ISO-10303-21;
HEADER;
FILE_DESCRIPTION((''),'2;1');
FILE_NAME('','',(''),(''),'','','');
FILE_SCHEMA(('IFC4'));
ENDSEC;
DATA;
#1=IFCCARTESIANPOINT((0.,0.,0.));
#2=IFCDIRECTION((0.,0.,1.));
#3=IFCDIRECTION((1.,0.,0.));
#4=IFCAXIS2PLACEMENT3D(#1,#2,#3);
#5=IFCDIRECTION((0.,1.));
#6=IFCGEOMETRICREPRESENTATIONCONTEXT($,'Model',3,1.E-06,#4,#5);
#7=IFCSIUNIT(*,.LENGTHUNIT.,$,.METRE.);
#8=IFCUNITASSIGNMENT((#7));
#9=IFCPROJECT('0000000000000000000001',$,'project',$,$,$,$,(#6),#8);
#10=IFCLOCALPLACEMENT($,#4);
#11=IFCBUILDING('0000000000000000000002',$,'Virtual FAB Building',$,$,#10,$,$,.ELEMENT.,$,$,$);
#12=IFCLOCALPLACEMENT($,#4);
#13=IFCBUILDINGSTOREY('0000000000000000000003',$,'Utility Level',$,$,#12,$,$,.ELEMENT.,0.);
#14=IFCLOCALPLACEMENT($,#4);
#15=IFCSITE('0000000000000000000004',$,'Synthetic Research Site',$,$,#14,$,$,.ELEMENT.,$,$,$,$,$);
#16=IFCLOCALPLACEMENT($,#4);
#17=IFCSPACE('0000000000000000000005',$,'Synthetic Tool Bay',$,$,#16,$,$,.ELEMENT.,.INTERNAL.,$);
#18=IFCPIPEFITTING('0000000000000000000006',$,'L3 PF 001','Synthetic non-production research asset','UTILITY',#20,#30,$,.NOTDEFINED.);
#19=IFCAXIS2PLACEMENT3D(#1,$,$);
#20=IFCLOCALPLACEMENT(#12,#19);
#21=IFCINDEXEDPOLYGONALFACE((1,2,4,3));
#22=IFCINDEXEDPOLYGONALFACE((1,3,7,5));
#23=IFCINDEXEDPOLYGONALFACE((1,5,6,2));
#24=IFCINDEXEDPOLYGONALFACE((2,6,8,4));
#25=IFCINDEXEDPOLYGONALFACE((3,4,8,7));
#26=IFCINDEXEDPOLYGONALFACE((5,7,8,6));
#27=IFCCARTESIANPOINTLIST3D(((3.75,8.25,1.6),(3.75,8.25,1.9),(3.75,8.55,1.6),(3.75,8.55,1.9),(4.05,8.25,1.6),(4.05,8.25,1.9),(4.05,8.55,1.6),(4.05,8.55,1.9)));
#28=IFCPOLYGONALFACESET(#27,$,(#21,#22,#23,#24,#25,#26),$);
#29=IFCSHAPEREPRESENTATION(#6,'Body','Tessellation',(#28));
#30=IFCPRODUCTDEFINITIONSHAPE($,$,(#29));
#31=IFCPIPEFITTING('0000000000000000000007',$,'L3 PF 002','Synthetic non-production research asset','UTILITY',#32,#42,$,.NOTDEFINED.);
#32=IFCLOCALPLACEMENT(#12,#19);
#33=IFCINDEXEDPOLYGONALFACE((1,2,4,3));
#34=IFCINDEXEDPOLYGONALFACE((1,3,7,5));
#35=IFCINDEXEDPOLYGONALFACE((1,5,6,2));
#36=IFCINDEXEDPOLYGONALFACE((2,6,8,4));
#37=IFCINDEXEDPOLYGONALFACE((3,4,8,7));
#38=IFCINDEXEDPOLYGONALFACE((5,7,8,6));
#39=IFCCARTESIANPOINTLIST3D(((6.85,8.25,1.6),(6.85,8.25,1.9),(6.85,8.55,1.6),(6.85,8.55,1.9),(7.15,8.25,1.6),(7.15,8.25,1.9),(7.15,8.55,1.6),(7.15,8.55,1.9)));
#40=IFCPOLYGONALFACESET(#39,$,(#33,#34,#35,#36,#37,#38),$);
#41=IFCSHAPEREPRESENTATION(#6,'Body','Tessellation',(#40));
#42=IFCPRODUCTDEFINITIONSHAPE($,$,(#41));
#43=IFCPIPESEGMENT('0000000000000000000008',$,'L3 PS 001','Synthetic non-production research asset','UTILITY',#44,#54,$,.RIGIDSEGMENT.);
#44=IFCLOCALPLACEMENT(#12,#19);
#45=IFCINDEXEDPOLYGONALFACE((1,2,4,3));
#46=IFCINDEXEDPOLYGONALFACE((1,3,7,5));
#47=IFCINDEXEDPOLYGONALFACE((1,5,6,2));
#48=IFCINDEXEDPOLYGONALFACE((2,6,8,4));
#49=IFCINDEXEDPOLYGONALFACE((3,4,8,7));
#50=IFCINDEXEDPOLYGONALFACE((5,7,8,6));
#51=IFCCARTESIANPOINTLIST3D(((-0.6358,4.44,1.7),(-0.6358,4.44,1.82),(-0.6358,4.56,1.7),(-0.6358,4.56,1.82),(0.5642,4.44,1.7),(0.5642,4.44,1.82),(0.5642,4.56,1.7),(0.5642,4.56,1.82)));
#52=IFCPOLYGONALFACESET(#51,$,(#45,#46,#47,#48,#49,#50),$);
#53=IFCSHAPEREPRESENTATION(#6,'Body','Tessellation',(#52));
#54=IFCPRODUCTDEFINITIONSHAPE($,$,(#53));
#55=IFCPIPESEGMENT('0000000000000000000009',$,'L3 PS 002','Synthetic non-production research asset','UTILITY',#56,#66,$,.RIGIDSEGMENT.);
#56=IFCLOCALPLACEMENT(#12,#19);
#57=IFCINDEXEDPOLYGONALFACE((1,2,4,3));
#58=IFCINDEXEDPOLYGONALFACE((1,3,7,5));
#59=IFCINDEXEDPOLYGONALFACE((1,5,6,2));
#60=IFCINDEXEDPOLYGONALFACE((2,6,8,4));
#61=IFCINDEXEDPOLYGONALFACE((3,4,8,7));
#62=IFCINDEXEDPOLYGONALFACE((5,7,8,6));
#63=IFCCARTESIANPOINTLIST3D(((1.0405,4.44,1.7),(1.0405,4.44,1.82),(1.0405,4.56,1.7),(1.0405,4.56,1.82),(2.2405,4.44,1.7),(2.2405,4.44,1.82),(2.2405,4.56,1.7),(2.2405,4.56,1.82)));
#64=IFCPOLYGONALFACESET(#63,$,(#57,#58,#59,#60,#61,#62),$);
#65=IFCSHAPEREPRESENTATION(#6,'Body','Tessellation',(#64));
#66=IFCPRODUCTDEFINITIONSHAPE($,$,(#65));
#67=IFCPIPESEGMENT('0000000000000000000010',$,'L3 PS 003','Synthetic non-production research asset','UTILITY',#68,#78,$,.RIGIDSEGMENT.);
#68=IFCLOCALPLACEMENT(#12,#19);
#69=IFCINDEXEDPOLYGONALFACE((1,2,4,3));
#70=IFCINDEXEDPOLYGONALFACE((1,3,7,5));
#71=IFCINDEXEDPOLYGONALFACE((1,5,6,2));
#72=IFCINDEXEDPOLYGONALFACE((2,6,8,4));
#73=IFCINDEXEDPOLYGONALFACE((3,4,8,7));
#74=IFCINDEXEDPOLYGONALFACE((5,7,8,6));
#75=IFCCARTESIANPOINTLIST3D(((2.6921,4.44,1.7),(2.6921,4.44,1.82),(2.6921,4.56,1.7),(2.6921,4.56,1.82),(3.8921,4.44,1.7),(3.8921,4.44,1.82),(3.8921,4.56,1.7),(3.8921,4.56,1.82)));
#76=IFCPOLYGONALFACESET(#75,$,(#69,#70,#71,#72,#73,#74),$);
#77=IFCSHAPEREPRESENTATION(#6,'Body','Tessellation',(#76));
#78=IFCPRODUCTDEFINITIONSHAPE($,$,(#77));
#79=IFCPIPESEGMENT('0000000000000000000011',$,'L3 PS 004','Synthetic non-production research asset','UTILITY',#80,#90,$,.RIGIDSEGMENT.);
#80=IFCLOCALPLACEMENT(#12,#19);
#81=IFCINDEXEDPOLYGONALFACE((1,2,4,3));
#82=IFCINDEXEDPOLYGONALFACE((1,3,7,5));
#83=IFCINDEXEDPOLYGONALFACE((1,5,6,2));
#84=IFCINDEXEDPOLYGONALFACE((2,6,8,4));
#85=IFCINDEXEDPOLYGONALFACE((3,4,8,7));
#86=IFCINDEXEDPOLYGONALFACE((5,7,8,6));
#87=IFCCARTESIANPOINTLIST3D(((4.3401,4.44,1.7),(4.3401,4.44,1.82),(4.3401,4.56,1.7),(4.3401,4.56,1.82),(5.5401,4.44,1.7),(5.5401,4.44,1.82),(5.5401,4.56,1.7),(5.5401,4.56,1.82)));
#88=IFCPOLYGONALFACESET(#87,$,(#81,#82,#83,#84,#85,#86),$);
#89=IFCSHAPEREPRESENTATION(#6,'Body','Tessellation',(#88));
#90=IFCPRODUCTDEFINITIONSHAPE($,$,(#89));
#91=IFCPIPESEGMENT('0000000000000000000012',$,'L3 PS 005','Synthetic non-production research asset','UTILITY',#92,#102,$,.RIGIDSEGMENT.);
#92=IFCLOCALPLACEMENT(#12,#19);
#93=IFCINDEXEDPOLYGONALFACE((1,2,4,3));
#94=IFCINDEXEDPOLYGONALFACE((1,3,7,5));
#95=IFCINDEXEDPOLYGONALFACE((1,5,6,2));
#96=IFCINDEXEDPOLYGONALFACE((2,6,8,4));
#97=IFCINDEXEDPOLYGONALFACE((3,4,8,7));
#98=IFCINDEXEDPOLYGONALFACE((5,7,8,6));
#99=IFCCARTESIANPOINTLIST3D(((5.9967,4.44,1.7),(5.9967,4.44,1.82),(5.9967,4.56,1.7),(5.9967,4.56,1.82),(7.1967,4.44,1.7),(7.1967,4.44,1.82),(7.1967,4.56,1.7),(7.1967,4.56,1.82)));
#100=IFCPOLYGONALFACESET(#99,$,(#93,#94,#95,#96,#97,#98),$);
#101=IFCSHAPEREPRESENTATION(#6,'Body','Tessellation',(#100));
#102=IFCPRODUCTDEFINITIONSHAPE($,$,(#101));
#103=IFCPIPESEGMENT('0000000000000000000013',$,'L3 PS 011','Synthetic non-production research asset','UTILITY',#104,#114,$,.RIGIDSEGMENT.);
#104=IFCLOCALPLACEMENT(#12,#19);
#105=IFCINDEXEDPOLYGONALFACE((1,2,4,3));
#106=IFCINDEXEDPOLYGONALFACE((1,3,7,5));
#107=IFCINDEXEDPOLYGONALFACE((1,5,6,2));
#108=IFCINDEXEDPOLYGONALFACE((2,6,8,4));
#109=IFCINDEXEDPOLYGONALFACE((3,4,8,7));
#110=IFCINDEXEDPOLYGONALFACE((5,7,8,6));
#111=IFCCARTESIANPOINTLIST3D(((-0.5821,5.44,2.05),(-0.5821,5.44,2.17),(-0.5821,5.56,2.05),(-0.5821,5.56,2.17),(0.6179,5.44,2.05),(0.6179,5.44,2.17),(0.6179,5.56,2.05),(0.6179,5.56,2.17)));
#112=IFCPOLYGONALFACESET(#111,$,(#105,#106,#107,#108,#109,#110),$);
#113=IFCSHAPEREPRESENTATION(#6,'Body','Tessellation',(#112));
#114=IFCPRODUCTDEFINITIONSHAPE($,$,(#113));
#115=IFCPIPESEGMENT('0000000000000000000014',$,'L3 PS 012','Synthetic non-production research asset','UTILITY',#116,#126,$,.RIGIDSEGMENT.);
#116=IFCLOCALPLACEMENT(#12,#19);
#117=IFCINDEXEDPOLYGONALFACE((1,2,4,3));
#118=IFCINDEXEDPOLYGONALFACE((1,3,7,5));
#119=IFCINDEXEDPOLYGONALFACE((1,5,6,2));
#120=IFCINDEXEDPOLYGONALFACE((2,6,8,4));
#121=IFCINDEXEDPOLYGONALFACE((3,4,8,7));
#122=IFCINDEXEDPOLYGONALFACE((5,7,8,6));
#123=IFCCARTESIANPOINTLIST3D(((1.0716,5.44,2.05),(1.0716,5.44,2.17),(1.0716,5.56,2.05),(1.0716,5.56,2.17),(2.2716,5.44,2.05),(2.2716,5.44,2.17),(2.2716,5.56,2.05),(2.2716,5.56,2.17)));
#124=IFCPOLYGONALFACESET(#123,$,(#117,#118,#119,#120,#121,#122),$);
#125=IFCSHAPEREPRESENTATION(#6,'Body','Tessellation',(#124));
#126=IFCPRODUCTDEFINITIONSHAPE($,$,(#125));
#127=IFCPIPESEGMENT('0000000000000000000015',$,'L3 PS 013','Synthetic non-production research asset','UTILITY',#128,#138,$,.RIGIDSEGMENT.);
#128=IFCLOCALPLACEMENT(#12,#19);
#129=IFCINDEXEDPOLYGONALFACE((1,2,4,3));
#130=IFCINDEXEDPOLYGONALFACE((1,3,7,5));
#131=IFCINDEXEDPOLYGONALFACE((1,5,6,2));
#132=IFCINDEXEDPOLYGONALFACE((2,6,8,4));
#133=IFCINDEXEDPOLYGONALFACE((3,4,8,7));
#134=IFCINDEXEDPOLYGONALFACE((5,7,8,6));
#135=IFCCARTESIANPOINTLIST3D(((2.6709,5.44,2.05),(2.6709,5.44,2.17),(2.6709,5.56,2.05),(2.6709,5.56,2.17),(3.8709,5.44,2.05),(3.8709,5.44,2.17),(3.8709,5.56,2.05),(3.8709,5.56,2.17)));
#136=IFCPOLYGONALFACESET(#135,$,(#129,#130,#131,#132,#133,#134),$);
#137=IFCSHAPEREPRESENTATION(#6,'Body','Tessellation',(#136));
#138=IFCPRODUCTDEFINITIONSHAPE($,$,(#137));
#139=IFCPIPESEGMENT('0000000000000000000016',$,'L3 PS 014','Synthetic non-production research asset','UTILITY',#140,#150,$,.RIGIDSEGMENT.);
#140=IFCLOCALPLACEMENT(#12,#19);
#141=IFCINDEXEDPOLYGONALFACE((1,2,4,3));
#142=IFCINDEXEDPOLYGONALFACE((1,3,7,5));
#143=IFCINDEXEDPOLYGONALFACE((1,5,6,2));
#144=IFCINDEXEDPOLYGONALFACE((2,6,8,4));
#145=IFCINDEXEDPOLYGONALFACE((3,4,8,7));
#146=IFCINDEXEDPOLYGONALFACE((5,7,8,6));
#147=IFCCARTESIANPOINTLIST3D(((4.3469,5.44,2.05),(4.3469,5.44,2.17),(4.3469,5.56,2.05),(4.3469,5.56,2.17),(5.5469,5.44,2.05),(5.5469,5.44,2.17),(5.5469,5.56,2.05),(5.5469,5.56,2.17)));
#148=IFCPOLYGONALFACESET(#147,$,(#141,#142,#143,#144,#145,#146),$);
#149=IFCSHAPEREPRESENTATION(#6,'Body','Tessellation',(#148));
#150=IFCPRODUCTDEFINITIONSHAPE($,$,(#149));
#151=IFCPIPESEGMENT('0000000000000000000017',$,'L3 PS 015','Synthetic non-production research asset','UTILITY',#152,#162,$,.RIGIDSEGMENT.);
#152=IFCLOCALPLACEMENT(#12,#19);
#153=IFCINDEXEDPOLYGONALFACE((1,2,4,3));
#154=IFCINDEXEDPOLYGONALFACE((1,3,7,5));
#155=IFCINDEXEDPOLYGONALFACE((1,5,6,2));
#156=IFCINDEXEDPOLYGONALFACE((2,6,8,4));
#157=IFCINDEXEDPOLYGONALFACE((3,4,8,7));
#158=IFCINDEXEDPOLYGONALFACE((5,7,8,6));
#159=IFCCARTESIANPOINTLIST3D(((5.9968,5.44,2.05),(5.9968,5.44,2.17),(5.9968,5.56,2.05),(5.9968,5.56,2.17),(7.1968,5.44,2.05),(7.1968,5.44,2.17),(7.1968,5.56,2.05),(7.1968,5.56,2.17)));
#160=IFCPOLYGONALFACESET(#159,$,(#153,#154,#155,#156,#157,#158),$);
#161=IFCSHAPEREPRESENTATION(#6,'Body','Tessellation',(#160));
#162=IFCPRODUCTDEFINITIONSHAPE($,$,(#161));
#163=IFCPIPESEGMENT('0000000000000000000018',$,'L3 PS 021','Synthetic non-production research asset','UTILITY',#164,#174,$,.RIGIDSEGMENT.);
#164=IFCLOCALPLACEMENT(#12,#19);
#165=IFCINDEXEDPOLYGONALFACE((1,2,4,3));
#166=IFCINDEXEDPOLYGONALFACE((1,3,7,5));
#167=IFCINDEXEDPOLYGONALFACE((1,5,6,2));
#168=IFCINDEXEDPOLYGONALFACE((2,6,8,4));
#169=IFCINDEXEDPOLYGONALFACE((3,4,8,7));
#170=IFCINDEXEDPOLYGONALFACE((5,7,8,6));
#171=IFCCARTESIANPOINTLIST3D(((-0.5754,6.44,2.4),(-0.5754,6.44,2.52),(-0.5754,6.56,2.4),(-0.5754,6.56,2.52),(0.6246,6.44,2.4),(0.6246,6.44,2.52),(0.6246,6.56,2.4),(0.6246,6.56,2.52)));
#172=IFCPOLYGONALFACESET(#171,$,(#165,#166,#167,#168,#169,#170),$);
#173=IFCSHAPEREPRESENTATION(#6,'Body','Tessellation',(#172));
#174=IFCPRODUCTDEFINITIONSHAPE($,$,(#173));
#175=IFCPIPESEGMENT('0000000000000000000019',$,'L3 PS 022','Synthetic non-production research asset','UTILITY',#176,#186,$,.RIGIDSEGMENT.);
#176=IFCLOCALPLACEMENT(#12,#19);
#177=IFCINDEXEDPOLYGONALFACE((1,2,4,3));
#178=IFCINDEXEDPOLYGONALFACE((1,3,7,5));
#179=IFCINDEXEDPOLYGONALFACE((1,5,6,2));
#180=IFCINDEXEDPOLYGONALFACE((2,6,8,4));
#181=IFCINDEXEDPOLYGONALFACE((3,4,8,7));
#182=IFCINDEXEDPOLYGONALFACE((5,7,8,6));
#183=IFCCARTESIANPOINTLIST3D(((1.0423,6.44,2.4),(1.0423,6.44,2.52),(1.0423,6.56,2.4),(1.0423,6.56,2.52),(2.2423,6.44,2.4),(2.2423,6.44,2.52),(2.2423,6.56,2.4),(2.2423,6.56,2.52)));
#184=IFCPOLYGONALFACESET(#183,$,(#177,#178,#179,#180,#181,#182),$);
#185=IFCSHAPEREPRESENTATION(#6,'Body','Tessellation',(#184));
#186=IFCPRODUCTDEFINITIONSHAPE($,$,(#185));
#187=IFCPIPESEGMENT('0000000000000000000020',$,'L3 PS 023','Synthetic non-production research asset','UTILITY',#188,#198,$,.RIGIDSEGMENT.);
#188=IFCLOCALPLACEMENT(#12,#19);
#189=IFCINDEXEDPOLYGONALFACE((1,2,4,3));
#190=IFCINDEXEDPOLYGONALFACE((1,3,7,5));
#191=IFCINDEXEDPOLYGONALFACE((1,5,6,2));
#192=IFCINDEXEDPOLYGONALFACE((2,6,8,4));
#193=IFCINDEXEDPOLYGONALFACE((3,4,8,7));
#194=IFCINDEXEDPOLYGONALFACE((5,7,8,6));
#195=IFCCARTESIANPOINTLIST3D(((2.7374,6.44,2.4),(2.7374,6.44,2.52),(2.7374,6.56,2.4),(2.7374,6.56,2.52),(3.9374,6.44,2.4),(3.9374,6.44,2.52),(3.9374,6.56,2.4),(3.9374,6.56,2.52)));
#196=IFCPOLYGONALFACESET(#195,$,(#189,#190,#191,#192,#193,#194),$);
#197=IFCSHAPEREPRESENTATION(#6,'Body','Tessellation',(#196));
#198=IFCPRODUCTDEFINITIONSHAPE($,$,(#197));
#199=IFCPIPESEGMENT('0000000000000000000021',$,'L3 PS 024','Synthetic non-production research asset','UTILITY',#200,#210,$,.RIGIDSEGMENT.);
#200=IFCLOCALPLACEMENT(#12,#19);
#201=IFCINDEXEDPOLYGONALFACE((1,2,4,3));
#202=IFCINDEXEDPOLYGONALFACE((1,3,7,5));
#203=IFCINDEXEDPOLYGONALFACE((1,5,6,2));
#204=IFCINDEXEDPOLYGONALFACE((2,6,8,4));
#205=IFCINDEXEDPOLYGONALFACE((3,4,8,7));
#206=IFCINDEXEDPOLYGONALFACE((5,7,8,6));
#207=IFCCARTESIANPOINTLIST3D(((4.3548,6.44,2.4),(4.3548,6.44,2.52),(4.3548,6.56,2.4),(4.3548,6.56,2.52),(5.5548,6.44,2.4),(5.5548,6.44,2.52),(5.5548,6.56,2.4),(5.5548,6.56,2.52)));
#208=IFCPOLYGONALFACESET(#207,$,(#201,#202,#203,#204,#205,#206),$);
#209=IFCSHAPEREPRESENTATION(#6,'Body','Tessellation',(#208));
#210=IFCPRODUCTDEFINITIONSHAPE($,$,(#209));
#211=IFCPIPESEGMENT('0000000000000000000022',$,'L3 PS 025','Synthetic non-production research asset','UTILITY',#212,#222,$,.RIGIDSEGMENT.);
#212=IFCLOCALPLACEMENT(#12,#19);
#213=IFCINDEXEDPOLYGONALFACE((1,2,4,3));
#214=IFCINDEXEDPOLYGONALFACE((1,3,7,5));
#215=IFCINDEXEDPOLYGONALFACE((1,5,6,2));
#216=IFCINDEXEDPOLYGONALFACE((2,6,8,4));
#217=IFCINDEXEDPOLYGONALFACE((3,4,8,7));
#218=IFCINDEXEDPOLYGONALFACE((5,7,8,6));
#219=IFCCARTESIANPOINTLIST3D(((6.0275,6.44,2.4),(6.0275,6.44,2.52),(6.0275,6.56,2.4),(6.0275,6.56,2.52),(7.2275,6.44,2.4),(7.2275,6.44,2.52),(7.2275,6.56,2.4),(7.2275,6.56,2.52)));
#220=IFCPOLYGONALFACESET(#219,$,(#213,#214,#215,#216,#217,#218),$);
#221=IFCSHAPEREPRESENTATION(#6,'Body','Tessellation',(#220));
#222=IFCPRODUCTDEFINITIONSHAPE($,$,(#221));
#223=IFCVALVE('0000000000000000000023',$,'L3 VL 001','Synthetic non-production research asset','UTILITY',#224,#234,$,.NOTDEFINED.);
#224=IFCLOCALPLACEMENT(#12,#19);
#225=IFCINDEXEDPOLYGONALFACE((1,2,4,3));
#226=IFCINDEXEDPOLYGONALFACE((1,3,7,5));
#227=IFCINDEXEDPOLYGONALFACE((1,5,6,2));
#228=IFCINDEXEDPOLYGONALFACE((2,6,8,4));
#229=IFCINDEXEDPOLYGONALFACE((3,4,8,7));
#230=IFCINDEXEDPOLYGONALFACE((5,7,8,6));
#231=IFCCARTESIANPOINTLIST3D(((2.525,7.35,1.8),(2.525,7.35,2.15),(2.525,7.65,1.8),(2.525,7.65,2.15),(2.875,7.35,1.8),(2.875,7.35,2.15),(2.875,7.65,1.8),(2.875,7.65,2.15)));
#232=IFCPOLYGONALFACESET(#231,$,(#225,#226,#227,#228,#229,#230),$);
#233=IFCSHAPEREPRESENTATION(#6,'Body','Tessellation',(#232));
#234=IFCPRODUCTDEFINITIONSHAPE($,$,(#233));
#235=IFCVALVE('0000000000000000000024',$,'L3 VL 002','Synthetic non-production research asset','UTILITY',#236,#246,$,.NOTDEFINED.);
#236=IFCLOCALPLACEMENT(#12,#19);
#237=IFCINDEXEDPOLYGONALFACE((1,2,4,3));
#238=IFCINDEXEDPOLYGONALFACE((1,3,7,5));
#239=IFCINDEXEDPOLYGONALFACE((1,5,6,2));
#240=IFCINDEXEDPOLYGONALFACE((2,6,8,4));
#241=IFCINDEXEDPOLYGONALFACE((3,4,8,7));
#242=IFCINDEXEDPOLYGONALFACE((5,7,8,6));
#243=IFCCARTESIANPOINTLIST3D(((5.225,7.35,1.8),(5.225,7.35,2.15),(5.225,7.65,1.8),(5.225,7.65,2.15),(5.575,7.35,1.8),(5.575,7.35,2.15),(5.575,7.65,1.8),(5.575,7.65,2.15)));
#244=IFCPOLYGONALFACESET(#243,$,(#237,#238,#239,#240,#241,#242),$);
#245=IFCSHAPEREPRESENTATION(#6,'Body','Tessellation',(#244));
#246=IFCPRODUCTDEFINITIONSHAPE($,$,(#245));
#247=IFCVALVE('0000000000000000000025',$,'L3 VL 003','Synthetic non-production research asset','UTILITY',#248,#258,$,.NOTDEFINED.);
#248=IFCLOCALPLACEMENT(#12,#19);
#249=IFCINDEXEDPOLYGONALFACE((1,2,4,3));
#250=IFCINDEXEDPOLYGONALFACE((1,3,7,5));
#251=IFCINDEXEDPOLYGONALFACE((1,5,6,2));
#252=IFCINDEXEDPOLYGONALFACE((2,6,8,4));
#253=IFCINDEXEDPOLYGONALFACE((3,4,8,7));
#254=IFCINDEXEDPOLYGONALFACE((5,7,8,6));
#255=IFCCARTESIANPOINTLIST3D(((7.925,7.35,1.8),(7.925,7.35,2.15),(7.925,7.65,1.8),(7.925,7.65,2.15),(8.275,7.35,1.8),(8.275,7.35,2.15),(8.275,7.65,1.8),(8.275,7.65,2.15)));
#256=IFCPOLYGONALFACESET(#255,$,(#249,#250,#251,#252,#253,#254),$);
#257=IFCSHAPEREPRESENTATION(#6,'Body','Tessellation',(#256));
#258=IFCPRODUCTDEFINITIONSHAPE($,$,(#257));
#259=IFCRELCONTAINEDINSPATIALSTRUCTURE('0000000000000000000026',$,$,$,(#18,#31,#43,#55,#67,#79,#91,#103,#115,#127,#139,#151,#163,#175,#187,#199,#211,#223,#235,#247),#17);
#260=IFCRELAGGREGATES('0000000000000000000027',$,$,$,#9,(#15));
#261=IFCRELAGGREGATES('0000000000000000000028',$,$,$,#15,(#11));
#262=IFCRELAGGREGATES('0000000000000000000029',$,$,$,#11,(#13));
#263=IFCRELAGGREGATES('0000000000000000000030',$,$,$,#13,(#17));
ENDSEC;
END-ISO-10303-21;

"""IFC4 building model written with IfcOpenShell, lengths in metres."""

from ifc_helpers import new_model, si_unit, direction, frame, origin_with_axes, origin_2d_with_axis, place, context, project, spatial, rectangle, extrude, element, save


model = new_model("IFC4")

# Units and contexts
model_context = context("Model", 3, precision=1e-06, world=origin_with_axes(), true_north=direction((0.0, 1.0)))
ifc_project = project(units=[si_unit("LENGTHUNIT", "METRE")], contexts=[model_context])

# Site, building, storey, space
site_placement = place(None, origin_with_axes())
site = spatial("IfcSite", under=ifc_project, at=site_placement, Name="Synthetic Research Site", CompositionType="ELEMENT")
building_placement = place(None, origin_with_axes())
building = spatial("IfcBuilding", under=site, at=building_placement, Name="Virtual FAB Building", CompositionType="ELEMENT")
storey_placement = place(None, origin_with_axes())
storey = spatial("IfcBuildingStorey", under=building, at=storey_placement, Name="Utility Level", CompositionType="ELEMENT", Elevation=0.0)
space_placement = place(None, origin_with_axes())
space = spatial("IfcSpace", under=storey, at=space_placement, Name="Synthetic Tool Bay", CompositionType="ELEMENT", PredefinedType="INTERNAL")

# Pipe fittings
for number, where, z_axis, x_axis, name in (
    (1, (3.9, 8.4, 1.6), (0.0, 0.0, 1.0), (1.0, 0.0, 0.0), "L3 PF 001"),
    (2, (7.0, 8.4, 1.6), (0.0, 0.0, 1.0), (1.0, 0.0, 0.0), "L3 PF 002"),
):
    element("IfcPipeFitting", number, at=place(None, frame(where, z_axis=z_axis, x_axis=x_axis)), inside=space, Name=name, Description="Synthetic non-production research asset", ObjectType="UTILITY", PredefinedType="NOTDEFINED", context=model_context, shape_type="SweptSolid", body=[
        extrude(rectangle(XDim=0.3, YDim=0.3, at=origin_2d_with_axis()), origin_with_axes(), (0.0, 0.0, 1.0), 0.3),
    ])

# Pipe segments
for number, where, z_axis, x_axis, name in (
    (3, (-0.0358, 4.5, 1.7), (0.0, 0.0, 1.0), (1.0, 0.0, 0.0), "L3 PS 001"),
    (4, (1.6405, 4.5, 1.7), (0.0, 0.0, 1.0), (1.0, 0.0, 0.0), "L3 PS 002"),
    (5, (3.2921, 4.5, 1.7), (0.0, 0.0, 1.0), (1.0, 0.0, 0.0), "L3 PS 003"),
    (6, (4.9401, 4.5, 1.7), (0.0, 0.0, 1.0), (1.0, 0.0, 0.0), "L3 PS 004"),
    (7, (6.5967, 4.5, 1.7), (0.0, 0.0, 1.0), (1.0, 0.0, 0.0), "L3 PS 005"),
    (8, (0.0179, 5.5, 2.05), (0.0, 0.0, 1.0), (1.0, 0.0, 0.0), "L3 PS 011"),
    (9, (1.6716, 5.5, 2.05), (0.0, 0.0, 1.0), (1.0, 0.0, 0.0), "L3 PS 012"),
    (10, (3.2709, 5.5, 2.05), (0.0, 0.0, 1.0), (1.0, 0.0, 0.0), "L3 PS 013"),
    (11, (4.9469, 5.5, 2.05), (0.0, 0.0, 1.0), (1.0, 0.0, 0.0), "L3 PS 014"),
    (12, (6.5968, 5.5, 2.05), (0.0, 0.0, 1.0), (1.0, 0.0, 0.0), "L3 PS 015"),
    (13, (0.0246, 6.5, 2.4), (0.0, 0.0, 1.0), (1.0, 0.0, 0.0), "L3 PS 021"),
    (14, (1.6423, 6.5, 2.4), (0.0, 0.0, 1.0), (1.0, 0.0, 0.0), "L3 PS 022"),
    (15, (3.3374, 6.5, 2.4), (0.0, 0.0, 1.0), (1.0, 0.0, 0.0), "L3 PS 023"),
    (16, (4.9548, 6.5, 2.4), (0.0, 0.0, 1.0), (1.0, 0.0, 0.0), "L3 PS 024"),
    (17, (6.6275, 6.5, 2.4), (0.0, 0.0, 1.0), (1.0, 0.0, 0.0), "L3 PS 025"),
):
    element("IfcPipeSegment", number, at=place(None, frame(where, z_axis=z_axis, x_axis=x_axis)), inside=space, Name=name, Description="Synthetic non-production research asset", ObjectType="UTILITY", PredefinedType="RIGIDSEGMENT", context=model_context, shape_type="SweptSolid", body=[
        extrude(rectangle(XDim=1.2, YDim=0.12, at=origin_2d_with_axis()), origin_with_axes(), (0.0, 0.0, 1.0), 0.12),
    ])

# Valves
for number, where, z_axis, x_axis, name in (
    (18, (2.7, 7.5, 1.8), (0.0, 0.0, 1.0), (1.0, 0.0, 0.0), "L3 VL 001"),
    (19, (5.4, 7.5, 1.8), (0.0, 0.0, 1.0), (1.0, 0.0, 0.0), "L3 VL 002"),
    (20, (8.1, 7.5, 1.8), (0.0, 0.0, 1.0), (1.0, 0.0, 0.0), "L3 VL 003"),
):
    element("IfcValve", number, at=place(None, frame(where, z_axis=z_axis, x_axis=x_axis)), inside=space, Name=name, Description="Synthetic non-production research asset", ObjectType="UTILITY", PredefinedType="NOTDEFINED", context=model_context, shape_type="SweptSolid", body=[
        extrude(rectangle(XDim=0.35, YDim=0.3, at=origin_2d_with_axis()), origin_with_axes(), (0.0, 0.0, 1.0), 0.35),
    ])

save(model, "model.ifc")
